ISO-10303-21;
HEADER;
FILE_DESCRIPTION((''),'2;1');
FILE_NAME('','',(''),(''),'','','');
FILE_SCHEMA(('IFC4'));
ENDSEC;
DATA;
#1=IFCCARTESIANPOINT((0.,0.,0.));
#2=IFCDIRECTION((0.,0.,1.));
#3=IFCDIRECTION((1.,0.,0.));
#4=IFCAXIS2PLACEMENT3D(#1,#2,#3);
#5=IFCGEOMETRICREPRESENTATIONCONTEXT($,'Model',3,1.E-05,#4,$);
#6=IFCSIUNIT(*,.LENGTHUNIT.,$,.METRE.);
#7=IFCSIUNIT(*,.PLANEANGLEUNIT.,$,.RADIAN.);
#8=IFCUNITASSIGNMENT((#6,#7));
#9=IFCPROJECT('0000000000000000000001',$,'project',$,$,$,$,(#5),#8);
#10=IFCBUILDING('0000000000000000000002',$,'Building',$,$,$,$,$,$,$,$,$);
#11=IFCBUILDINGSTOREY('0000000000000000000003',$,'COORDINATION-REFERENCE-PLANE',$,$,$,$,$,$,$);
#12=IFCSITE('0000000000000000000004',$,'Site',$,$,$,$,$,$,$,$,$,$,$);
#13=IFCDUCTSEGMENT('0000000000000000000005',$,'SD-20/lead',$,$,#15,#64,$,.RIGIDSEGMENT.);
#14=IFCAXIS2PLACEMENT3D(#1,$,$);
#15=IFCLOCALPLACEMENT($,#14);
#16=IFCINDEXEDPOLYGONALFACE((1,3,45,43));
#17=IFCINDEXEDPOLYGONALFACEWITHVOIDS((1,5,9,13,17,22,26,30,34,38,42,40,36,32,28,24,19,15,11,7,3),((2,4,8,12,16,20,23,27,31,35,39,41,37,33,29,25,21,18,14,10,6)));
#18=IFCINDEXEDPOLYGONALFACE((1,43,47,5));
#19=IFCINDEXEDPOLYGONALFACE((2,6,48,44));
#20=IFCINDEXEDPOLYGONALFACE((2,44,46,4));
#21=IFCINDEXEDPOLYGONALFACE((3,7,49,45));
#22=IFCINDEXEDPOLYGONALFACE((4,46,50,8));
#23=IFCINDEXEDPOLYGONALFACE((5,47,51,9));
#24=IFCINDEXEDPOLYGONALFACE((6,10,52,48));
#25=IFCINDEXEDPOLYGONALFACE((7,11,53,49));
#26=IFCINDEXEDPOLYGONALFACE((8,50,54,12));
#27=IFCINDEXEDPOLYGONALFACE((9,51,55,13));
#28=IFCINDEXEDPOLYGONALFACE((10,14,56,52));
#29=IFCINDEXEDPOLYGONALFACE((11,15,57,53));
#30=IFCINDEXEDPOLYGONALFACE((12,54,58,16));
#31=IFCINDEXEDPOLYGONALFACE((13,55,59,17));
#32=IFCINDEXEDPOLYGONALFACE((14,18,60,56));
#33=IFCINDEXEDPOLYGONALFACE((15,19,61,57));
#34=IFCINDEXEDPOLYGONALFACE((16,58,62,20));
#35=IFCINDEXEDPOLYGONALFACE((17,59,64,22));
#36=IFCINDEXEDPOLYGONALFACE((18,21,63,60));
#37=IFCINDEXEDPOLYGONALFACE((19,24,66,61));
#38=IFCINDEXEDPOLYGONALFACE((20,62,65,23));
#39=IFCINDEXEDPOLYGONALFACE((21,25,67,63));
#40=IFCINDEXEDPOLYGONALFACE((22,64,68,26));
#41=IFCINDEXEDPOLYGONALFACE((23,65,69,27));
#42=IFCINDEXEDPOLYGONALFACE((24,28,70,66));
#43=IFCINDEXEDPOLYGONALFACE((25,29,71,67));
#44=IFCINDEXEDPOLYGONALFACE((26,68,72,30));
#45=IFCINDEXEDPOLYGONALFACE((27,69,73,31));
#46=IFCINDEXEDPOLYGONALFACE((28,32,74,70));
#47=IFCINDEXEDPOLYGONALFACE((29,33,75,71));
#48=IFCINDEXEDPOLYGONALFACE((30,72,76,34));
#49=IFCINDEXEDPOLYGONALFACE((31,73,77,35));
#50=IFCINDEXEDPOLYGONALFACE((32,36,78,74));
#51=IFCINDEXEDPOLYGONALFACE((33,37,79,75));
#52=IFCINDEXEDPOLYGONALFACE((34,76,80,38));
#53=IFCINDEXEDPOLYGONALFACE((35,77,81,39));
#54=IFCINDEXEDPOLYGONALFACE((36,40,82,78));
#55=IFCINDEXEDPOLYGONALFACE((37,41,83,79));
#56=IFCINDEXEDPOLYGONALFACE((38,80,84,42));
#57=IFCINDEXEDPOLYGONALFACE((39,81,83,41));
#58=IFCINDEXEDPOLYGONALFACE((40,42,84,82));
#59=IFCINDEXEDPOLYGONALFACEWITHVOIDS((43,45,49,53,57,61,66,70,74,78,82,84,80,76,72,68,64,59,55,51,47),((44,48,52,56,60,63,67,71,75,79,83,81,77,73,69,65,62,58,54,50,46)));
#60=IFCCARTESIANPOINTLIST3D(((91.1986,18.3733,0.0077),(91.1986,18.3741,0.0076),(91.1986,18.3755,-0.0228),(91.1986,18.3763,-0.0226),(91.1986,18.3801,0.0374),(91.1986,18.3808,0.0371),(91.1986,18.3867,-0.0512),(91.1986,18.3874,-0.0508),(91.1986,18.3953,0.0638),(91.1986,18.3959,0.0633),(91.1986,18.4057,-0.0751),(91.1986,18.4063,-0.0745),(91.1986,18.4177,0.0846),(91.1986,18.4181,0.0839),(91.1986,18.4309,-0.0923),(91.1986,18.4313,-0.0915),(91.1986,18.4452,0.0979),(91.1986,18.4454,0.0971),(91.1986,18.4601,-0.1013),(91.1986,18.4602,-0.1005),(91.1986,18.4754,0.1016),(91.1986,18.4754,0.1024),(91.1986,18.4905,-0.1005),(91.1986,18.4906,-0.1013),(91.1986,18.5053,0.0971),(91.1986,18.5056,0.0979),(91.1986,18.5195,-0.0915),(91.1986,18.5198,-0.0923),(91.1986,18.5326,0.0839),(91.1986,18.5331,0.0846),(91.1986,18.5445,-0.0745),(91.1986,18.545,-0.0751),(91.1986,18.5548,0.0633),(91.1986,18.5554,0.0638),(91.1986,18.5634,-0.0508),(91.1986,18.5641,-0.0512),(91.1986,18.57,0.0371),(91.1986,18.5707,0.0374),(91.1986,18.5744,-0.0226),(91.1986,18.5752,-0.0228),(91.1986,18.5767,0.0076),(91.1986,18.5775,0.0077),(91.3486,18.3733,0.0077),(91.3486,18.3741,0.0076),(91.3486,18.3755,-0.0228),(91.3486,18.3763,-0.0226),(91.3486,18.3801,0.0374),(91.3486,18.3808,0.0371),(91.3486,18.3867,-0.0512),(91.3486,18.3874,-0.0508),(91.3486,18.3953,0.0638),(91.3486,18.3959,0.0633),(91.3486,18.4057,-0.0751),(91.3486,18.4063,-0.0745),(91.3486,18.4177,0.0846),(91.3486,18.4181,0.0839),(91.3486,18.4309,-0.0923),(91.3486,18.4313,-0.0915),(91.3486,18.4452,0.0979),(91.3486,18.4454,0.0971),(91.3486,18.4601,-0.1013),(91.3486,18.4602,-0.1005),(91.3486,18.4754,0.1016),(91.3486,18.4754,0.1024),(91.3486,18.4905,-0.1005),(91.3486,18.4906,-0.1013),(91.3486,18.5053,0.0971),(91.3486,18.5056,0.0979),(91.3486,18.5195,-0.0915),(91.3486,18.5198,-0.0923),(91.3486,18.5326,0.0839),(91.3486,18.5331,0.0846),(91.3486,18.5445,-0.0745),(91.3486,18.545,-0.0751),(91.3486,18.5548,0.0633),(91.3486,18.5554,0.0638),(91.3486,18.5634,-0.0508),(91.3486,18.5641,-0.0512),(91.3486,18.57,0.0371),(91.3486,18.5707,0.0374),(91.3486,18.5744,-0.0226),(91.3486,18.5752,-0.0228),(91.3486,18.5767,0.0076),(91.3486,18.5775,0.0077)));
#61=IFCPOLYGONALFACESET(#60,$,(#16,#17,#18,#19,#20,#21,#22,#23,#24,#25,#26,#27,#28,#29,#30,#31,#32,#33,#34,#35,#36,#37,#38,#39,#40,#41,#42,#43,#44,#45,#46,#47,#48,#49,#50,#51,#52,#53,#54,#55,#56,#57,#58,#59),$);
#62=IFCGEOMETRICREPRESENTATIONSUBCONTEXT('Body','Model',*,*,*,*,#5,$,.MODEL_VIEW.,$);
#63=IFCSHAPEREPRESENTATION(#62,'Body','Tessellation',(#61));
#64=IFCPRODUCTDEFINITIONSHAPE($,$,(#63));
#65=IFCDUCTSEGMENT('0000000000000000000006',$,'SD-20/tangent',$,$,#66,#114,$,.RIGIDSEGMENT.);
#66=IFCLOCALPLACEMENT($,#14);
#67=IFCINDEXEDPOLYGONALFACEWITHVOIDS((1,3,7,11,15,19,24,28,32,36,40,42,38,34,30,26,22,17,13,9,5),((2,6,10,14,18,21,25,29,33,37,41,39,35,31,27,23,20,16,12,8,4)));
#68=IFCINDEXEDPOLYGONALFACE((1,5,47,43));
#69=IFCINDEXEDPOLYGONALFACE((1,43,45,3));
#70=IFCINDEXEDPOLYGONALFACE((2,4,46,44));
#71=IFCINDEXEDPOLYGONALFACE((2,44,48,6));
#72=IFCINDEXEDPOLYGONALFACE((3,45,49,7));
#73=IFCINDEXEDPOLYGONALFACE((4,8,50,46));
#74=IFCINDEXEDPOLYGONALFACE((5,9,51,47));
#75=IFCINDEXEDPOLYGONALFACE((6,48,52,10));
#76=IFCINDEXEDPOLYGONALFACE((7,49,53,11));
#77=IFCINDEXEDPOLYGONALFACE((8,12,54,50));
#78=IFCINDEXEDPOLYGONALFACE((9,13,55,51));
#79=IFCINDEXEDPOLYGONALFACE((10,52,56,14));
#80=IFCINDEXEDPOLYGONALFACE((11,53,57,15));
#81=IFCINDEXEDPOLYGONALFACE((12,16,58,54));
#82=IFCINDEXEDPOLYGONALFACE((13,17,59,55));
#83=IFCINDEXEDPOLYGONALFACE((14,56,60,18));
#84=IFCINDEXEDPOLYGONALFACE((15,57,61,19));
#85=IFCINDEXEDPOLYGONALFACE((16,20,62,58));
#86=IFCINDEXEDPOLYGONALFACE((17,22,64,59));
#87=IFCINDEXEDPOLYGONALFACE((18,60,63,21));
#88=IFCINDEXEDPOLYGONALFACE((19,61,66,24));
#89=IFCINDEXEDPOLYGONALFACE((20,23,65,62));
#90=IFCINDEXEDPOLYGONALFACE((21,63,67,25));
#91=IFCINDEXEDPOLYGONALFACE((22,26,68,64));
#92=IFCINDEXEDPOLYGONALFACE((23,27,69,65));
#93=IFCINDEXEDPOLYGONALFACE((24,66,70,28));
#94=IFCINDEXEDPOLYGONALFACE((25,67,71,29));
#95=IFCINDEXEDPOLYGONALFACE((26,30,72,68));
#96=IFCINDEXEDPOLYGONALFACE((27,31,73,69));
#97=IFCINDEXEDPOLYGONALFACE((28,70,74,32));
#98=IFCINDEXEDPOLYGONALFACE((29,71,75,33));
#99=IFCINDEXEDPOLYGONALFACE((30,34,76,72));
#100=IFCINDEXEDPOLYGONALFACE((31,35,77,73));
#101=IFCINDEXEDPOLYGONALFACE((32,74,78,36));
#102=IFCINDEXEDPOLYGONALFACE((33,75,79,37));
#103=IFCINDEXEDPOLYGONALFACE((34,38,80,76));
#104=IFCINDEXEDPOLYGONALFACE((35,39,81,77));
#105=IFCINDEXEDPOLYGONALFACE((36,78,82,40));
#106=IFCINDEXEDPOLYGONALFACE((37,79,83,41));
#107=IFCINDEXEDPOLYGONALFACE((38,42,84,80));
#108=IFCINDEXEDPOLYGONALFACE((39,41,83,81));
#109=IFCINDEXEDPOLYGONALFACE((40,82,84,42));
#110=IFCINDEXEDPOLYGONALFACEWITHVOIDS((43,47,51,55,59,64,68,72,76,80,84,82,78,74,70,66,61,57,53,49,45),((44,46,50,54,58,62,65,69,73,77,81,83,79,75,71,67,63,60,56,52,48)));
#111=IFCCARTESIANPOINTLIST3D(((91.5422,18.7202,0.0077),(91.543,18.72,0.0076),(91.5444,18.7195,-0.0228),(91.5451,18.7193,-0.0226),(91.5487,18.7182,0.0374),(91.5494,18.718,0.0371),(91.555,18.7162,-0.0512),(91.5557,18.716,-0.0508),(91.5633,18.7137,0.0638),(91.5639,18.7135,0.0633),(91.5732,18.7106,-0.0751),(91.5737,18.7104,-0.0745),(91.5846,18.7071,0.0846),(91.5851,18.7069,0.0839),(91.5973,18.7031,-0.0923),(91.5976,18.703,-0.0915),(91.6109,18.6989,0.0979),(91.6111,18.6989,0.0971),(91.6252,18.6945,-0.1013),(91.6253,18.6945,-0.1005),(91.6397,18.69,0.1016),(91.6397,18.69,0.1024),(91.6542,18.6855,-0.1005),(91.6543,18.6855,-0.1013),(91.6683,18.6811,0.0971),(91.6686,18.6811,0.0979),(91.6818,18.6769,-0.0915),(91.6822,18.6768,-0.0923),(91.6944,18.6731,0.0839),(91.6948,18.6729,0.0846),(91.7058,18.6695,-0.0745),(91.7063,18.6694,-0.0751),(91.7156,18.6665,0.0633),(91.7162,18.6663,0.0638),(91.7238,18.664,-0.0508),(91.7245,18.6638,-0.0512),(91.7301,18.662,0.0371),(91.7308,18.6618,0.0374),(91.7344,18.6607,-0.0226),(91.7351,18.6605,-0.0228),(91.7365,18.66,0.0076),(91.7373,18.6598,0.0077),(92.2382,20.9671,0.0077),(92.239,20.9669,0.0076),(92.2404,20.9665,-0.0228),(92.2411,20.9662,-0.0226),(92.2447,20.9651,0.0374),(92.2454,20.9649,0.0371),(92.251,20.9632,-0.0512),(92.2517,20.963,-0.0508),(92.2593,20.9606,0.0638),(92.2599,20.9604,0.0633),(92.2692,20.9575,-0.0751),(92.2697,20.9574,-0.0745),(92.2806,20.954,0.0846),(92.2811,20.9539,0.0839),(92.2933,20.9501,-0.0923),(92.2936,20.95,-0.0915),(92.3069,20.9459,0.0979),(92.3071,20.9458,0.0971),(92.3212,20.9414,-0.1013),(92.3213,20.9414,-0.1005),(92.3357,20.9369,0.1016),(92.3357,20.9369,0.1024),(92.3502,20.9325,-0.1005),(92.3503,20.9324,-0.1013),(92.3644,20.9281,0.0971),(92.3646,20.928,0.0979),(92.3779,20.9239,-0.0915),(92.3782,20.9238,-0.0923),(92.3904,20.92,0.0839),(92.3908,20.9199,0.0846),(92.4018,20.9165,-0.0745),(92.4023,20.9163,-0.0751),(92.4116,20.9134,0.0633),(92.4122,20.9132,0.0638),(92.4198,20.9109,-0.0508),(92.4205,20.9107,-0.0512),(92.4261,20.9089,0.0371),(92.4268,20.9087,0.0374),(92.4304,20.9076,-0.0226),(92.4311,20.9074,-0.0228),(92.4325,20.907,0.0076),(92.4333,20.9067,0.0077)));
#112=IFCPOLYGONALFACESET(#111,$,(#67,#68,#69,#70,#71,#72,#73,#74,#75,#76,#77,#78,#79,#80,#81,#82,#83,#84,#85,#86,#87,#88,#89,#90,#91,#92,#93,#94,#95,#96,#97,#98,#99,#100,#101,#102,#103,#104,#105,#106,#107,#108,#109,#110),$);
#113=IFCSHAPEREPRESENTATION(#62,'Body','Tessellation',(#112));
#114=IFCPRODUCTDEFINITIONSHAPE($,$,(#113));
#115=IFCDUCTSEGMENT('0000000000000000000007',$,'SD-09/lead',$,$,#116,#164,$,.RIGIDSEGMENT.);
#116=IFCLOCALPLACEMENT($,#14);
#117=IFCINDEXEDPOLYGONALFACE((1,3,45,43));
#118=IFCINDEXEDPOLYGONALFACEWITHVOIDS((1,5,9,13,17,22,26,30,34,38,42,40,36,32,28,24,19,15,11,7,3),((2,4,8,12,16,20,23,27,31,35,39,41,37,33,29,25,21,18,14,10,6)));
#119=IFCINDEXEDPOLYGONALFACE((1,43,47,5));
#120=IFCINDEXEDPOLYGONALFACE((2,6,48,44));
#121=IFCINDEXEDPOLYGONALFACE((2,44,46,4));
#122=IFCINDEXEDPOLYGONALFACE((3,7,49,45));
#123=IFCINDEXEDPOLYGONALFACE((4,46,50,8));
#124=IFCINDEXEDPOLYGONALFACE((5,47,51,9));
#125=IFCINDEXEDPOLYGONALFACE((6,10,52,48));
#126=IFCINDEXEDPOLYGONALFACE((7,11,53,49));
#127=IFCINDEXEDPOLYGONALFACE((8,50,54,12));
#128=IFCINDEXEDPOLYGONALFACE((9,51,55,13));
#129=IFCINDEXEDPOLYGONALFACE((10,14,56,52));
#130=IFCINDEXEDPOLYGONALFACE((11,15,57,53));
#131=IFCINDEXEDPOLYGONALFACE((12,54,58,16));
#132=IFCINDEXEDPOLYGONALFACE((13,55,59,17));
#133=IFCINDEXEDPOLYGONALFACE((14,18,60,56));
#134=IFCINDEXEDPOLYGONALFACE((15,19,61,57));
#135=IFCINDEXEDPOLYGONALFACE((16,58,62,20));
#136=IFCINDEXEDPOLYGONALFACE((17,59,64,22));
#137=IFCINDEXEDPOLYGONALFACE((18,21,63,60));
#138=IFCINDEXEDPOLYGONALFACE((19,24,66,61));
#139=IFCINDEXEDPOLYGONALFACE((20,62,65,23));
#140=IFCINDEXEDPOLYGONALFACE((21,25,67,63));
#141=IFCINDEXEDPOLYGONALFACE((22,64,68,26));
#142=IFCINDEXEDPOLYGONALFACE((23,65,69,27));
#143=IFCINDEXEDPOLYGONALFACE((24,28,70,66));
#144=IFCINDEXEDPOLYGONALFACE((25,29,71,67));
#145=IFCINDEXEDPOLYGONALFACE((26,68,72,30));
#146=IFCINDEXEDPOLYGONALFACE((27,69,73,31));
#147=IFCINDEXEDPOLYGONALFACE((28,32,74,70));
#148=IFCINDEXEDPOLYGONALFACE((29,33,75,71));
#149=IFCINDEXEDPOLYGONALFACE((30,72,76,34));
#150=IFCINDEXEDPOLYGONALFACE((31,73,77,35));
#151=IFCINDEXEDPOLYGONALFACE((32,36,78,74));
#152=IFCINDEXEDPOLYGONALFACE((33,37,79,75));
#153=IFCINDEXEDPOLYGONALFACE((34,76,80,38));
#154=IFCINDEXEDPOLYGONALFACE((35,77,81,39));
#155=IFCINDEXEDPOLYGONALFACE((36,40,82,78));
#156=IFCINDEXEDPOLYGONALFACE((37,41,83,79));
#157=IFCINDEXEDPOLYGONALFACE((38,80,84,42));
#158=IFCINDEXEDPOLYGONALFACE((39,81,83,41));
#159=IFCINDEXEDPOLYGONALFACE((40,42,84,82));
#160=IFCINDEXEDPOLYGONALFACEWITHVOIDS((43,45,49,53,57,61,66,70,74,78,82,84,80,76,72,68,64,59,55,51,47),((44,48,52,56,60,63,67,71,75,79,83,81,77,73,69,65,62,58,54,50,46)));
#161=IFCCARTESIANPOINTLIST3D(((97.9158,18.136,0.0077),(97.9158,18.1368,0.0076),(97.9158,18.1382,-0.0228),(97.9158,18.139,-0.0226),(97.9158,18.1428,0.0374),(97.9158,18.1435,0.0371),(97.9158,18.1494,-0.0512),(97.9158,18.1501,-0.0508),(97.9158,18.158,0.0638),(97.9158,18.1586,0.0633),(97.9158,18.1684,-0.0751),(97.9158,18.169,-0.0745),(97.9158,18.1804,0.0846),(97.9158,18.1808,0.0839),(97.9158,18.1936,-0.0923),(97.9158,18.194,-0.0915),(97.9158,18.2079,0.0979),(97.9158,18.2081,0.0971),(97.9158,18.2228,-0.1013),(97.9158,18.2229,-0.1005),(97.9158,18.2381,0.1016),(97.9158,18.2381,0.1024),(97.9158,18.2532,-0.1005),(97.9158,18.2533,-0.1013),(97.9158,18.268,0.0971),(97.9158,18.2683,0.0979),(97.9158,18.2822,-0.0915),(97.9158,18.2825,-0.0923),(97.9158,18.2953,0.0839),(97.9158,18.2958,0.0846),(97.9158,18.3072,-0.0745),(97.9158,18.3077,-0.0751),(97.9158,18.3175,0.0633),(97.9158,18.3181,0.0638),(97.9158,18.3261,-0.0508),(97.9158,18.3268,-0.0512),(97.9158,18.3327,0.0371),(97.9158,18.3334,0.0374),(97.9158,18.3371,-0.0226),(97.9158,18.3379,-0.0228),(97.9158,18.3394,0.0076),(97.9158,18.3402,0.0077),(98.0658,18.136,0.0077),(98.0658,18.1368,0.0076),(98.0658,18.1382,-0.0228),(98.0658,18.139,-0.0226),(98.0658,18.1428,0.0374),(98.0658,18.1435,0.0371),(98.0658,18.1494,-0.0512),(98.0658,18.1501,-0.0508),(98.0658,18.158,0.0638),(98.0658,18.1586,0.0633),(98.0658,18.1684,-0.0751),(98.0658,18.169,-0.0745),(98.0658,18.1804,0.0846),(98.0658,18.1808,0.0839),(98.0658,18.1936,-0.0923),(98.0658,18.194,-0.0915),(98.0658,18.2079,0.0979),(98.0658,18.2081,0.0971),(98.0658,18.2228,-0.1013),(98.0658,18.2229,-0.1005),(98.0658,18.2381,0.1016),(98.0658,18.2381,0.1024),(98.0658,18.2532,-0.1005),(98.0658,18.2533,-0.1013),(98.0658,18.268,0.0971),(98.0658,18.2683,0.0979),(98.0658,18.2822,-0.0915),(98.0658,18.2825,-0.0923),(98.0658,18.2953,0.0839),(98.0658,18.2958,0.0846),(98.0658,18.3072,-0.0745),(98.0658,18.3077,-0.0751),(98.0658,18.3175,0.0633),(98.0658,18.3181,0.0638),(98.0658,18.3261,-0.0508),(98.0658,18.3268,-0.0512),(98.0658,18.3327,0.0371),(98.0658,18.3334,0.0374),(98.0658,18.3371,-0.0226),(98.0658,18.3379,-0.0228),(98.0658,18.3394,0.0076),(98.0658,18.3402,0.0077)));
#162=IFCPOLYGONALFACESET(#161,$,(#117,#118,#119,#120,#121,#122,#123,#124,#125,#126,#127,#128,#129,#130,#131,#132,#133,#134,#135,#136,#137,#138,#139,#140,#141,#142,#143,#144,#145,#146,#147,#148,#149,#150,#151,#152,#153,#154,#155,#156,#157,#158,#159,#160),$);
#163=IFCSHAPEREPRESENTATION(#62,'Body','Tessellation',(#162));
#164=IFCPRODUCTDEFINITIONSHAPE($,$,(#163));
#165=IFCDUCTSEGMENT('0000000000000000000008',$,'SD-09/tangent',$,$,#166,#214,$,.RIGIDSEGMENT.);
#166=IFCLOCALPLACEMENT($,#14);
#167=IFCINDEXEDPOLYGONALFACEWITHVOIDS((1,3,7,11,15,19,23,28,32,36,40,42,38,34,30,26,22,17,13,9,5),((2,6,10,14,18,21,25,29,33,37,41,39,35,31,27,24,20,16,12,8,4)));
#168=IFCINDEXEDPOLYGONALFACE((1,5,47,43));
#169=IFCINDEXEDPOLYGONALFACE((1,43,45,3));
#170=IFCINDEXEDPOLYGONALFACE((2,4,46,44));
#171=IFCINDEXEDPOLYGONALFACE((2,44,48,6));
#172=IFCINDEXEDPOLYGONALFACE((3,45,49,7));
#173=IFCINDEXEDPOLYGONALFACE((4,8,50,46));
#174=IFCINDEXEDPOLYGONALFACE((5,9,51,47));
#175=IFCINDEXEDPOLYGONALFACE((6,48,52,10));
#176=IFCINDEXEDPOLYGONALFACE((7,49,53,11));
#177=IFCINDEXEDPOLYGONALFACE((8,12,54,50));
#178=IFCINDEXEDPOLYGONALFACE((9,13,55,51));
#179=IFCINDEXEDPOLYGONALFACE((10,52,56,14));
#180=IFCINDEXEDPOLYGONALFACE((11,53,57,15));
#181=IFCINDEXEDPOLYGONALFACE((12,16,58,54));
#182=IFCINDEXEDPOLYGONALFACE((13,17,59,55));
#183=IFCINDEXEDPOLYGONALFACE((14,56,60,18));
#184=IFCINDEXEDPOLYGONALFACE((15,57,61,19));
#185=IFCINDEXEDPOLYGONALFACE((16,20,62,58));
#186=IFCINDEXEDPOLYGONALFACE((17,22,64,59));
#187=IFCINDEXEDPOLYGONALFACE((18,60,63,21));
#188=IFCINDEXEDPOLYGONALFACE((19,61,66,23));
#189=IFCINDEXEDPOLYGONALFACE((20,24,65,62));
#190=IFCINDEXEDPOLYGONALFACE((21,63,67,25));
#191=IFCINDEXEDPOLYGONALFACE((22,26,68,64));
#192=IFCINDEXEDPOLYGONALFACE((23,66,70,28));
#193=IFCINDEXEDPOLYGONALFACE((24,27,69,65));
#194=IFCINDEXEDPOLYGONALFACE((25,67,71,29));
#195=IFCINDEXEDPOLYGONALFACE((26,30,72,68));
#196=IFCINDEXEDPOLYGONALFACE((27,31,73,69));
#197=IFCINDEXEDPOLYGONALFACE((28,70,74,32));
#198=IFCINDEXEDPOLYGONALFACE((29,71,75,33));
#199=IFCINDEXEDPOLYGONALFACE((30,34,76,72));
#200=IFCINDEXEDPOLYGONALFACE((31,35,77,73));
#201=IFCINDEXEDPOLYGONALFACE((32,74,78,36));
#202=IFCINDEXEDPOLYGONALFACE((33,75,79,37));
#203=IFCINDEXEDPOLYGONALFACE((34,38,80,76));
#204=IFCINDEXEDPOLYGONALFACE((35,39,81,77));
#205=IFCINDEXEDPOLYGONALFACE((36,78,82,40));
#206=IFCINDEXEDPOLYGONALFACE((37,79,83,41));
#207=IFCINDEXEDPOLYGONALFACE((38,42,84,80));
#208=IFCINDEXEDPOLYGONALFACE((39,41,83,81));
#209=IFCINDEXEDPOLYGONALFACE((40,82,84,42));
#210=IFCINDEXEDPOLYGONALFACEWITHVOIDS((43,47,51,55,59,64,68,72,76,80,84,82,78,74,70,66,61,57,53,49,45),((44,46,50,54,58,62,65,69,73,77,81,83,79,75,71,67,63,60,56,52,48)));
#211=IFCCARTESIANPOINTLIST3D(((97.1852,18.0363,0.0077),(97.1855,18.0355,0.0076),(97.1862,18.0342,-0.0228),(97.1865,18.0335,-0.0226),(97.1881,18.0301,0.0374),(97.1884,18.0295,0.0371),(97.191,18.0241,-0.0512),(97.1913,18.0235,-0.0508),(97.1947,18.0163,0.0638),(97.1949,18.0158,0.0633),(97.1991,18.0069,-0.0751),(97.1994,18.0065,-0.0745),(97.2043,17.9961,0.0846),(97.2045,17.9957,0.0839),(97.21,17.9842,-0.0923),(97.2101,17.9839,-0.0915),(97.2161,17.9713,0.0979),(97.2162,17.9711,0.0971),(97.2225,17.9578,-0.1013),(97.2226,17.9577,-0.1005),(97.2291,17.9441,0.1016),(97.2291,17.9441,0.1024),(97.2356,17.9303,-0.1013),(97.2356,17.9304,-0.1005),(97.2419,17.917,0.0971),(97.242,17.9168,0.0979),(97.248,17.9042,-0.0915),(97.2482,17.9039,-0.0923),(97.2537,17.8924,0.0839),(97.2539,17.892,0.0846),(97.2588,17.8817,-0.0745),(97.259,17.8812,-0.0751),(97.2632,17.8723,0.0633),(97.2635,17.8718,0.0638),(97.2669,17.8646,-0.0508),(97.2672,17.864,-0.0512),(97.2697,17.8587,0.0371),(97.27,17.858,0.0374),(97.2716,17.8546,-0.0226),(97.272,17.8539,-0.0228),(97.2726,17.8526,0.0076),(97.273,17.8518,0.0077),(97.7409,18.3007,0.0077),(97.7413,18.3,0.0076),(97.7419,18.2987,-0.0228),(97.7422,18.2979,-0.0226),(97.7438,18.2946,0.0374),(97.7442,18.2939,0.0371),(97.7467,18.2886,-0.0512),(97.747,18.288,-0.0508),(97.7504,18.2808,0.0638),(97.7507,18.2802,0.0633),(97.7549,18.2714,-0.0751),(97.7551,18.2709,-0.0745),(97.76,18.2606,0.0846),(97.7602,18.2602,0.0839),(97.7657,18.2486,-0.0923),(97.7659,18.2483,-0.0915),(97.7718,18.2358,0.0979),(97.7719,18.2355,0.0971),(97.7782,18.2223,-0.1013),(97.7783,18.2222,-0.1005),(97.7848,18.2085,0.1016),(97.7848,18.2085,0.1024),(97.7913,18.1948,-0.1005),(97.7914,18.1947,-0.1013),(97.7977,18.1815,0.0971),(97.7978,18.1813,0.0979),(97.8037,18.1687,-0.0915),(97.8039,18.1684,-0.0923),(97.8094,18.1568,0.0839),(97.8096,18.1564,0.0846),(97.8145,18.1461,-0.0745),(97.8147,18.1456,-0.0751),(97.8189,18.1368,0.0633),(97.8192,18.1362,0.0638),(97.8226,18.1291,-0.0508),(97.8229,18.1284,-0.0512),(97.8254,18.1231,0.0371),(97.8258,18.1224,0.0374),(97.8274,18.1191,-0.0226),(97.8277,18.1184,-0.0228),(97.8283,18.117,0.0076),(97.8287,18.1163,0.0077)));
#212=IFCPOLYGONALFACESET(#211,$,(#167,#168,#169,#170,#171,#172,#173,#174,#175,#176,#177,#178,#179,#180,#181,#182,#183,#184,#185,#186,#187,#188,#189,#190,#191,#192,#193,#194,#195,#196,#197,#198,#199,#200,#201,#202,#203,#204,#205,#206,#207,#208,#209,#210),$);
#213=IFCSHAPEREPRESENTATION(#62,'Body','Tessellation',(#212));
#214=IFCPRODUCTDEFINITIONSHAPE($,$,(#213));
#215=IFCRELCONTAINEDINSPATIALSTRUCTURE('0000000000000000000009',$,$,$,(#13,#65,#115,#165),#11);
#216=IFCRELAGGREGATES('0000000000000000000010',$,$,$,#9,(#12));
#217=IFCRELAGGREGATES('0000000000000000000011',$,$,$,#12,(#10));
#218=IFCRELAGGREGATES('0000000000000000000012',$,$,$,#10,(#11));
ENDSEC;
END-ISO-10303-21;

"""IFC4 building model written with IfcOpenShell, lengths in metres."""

from ifc_helpers import new_model, si_unit, frame, origin_with_axes, place, context, subcontext, project, spatial, hollow_circle, extrude, element, save


model = new_model("IFC4")

# Units and contexts
model_context_1 = context("Model", 3, precision=1e-05, world=origin_with_axes())
body_context_1 = subcontext(model_context_1, "Body", "Model", "MODEL_VIEW")
ifc_project = project(units=[si_unit("LENGTHUNIT", "METRE"), si_unit("PLANEANGLEUNIT", "RADIAN")], contexts=[model_context_1])

# Site, building, storey
site = spatial("IfcSite", under=ifc_project, Name="Site")
building = spatial("IfcBuilding", under=site, Name="Building")
storey = spatial("IfcBuildingStorey", under=building, Name="COORDINATION-REFERENCE-PLANE")

# Duct segment
for number, where, z_axis, x_axis, name in (
    (1, (91.1986, 18.4754, 0.0), (1.0, 0.0, 0.0), (0.0, 0.0, 1.0), "SD-20/lead"),
):
    element("IfcDuctSegment", number, at=place(None, frame(where, z_axis=z_axis, x_axis=x_axis)), inside=storey, Name=name, PredefinedType="RIGIDSEGMENT", context=body_context_1, shape_type="SweptSolid", body=[
        extrude(hollow_circle(Radius=0.1024, WallThickness=0.0008), origin_with_axes(), (0.0, 0.0, 1.0), 0.15),
    ])

# Duct segment
duct_segment_1_placement = place(None, frame((91.6397, 18.69, 0.0), z_axis=(0.295887, 0.955223, 0.0), x_axis=(0.0, 0.0, 1.0)))
element("IfcDuctSegment", 2, at=duct_segment_1_placement, inside=storey, Name="SD-20/tangent", PredefinedType="RIGIDSEGMENT", context=body_context_1, shape_type="SweptSolid", body=[
    extrude(hollow_circle(Radius=0.1024, WallThickness=0.0008), origin_with_axes(), (0.0, 0.0, 1.0), 2.3523),
])

# Duct segment
duct_segment_2_placement = place(None, frame((98.0658, 18.2381, 0.0), z_axis=(-1.0, 0.0, 0.0), x_axis=(0.0, 0.0, 1.0)))
element("IfcDuctSegment", 3, at=duct_segment_2_placement, inside=storey, Name="SD-09/lead", PredefinedType="RIGIDSEGMENT", context=body_context_1, shape_type="SweptSolid", body=[
    extrude(hollow_circle(Radius=0.1024, WallThickness=0.0008), origin_with_axes(), (0.0, 0.0, 1.0), 0.15),
])

# Duct segment
duct_segment_3_placement = place(None, frame((97.7848, 18.2085, 0.0), z_axis=(-0.902975, -0.429693, 0.0), x_axis=(0.0, 0.0, 1.0)))
element("IfcDuctSegment", 4, at=duct_segment_3_placement, inside=storey, Name="SD-09/tangent", PredefinedType="RIGIDSEGMENT", context=body_context_1, shape_type="SweptSolid", body=[
    extrude(hollow_circle(Radius=0.1024, WallThickness=0.0008), origin_with_axes(), (0.0, 0.0, 1.0), 0.6154),
])

save(model, "model.ifc")
